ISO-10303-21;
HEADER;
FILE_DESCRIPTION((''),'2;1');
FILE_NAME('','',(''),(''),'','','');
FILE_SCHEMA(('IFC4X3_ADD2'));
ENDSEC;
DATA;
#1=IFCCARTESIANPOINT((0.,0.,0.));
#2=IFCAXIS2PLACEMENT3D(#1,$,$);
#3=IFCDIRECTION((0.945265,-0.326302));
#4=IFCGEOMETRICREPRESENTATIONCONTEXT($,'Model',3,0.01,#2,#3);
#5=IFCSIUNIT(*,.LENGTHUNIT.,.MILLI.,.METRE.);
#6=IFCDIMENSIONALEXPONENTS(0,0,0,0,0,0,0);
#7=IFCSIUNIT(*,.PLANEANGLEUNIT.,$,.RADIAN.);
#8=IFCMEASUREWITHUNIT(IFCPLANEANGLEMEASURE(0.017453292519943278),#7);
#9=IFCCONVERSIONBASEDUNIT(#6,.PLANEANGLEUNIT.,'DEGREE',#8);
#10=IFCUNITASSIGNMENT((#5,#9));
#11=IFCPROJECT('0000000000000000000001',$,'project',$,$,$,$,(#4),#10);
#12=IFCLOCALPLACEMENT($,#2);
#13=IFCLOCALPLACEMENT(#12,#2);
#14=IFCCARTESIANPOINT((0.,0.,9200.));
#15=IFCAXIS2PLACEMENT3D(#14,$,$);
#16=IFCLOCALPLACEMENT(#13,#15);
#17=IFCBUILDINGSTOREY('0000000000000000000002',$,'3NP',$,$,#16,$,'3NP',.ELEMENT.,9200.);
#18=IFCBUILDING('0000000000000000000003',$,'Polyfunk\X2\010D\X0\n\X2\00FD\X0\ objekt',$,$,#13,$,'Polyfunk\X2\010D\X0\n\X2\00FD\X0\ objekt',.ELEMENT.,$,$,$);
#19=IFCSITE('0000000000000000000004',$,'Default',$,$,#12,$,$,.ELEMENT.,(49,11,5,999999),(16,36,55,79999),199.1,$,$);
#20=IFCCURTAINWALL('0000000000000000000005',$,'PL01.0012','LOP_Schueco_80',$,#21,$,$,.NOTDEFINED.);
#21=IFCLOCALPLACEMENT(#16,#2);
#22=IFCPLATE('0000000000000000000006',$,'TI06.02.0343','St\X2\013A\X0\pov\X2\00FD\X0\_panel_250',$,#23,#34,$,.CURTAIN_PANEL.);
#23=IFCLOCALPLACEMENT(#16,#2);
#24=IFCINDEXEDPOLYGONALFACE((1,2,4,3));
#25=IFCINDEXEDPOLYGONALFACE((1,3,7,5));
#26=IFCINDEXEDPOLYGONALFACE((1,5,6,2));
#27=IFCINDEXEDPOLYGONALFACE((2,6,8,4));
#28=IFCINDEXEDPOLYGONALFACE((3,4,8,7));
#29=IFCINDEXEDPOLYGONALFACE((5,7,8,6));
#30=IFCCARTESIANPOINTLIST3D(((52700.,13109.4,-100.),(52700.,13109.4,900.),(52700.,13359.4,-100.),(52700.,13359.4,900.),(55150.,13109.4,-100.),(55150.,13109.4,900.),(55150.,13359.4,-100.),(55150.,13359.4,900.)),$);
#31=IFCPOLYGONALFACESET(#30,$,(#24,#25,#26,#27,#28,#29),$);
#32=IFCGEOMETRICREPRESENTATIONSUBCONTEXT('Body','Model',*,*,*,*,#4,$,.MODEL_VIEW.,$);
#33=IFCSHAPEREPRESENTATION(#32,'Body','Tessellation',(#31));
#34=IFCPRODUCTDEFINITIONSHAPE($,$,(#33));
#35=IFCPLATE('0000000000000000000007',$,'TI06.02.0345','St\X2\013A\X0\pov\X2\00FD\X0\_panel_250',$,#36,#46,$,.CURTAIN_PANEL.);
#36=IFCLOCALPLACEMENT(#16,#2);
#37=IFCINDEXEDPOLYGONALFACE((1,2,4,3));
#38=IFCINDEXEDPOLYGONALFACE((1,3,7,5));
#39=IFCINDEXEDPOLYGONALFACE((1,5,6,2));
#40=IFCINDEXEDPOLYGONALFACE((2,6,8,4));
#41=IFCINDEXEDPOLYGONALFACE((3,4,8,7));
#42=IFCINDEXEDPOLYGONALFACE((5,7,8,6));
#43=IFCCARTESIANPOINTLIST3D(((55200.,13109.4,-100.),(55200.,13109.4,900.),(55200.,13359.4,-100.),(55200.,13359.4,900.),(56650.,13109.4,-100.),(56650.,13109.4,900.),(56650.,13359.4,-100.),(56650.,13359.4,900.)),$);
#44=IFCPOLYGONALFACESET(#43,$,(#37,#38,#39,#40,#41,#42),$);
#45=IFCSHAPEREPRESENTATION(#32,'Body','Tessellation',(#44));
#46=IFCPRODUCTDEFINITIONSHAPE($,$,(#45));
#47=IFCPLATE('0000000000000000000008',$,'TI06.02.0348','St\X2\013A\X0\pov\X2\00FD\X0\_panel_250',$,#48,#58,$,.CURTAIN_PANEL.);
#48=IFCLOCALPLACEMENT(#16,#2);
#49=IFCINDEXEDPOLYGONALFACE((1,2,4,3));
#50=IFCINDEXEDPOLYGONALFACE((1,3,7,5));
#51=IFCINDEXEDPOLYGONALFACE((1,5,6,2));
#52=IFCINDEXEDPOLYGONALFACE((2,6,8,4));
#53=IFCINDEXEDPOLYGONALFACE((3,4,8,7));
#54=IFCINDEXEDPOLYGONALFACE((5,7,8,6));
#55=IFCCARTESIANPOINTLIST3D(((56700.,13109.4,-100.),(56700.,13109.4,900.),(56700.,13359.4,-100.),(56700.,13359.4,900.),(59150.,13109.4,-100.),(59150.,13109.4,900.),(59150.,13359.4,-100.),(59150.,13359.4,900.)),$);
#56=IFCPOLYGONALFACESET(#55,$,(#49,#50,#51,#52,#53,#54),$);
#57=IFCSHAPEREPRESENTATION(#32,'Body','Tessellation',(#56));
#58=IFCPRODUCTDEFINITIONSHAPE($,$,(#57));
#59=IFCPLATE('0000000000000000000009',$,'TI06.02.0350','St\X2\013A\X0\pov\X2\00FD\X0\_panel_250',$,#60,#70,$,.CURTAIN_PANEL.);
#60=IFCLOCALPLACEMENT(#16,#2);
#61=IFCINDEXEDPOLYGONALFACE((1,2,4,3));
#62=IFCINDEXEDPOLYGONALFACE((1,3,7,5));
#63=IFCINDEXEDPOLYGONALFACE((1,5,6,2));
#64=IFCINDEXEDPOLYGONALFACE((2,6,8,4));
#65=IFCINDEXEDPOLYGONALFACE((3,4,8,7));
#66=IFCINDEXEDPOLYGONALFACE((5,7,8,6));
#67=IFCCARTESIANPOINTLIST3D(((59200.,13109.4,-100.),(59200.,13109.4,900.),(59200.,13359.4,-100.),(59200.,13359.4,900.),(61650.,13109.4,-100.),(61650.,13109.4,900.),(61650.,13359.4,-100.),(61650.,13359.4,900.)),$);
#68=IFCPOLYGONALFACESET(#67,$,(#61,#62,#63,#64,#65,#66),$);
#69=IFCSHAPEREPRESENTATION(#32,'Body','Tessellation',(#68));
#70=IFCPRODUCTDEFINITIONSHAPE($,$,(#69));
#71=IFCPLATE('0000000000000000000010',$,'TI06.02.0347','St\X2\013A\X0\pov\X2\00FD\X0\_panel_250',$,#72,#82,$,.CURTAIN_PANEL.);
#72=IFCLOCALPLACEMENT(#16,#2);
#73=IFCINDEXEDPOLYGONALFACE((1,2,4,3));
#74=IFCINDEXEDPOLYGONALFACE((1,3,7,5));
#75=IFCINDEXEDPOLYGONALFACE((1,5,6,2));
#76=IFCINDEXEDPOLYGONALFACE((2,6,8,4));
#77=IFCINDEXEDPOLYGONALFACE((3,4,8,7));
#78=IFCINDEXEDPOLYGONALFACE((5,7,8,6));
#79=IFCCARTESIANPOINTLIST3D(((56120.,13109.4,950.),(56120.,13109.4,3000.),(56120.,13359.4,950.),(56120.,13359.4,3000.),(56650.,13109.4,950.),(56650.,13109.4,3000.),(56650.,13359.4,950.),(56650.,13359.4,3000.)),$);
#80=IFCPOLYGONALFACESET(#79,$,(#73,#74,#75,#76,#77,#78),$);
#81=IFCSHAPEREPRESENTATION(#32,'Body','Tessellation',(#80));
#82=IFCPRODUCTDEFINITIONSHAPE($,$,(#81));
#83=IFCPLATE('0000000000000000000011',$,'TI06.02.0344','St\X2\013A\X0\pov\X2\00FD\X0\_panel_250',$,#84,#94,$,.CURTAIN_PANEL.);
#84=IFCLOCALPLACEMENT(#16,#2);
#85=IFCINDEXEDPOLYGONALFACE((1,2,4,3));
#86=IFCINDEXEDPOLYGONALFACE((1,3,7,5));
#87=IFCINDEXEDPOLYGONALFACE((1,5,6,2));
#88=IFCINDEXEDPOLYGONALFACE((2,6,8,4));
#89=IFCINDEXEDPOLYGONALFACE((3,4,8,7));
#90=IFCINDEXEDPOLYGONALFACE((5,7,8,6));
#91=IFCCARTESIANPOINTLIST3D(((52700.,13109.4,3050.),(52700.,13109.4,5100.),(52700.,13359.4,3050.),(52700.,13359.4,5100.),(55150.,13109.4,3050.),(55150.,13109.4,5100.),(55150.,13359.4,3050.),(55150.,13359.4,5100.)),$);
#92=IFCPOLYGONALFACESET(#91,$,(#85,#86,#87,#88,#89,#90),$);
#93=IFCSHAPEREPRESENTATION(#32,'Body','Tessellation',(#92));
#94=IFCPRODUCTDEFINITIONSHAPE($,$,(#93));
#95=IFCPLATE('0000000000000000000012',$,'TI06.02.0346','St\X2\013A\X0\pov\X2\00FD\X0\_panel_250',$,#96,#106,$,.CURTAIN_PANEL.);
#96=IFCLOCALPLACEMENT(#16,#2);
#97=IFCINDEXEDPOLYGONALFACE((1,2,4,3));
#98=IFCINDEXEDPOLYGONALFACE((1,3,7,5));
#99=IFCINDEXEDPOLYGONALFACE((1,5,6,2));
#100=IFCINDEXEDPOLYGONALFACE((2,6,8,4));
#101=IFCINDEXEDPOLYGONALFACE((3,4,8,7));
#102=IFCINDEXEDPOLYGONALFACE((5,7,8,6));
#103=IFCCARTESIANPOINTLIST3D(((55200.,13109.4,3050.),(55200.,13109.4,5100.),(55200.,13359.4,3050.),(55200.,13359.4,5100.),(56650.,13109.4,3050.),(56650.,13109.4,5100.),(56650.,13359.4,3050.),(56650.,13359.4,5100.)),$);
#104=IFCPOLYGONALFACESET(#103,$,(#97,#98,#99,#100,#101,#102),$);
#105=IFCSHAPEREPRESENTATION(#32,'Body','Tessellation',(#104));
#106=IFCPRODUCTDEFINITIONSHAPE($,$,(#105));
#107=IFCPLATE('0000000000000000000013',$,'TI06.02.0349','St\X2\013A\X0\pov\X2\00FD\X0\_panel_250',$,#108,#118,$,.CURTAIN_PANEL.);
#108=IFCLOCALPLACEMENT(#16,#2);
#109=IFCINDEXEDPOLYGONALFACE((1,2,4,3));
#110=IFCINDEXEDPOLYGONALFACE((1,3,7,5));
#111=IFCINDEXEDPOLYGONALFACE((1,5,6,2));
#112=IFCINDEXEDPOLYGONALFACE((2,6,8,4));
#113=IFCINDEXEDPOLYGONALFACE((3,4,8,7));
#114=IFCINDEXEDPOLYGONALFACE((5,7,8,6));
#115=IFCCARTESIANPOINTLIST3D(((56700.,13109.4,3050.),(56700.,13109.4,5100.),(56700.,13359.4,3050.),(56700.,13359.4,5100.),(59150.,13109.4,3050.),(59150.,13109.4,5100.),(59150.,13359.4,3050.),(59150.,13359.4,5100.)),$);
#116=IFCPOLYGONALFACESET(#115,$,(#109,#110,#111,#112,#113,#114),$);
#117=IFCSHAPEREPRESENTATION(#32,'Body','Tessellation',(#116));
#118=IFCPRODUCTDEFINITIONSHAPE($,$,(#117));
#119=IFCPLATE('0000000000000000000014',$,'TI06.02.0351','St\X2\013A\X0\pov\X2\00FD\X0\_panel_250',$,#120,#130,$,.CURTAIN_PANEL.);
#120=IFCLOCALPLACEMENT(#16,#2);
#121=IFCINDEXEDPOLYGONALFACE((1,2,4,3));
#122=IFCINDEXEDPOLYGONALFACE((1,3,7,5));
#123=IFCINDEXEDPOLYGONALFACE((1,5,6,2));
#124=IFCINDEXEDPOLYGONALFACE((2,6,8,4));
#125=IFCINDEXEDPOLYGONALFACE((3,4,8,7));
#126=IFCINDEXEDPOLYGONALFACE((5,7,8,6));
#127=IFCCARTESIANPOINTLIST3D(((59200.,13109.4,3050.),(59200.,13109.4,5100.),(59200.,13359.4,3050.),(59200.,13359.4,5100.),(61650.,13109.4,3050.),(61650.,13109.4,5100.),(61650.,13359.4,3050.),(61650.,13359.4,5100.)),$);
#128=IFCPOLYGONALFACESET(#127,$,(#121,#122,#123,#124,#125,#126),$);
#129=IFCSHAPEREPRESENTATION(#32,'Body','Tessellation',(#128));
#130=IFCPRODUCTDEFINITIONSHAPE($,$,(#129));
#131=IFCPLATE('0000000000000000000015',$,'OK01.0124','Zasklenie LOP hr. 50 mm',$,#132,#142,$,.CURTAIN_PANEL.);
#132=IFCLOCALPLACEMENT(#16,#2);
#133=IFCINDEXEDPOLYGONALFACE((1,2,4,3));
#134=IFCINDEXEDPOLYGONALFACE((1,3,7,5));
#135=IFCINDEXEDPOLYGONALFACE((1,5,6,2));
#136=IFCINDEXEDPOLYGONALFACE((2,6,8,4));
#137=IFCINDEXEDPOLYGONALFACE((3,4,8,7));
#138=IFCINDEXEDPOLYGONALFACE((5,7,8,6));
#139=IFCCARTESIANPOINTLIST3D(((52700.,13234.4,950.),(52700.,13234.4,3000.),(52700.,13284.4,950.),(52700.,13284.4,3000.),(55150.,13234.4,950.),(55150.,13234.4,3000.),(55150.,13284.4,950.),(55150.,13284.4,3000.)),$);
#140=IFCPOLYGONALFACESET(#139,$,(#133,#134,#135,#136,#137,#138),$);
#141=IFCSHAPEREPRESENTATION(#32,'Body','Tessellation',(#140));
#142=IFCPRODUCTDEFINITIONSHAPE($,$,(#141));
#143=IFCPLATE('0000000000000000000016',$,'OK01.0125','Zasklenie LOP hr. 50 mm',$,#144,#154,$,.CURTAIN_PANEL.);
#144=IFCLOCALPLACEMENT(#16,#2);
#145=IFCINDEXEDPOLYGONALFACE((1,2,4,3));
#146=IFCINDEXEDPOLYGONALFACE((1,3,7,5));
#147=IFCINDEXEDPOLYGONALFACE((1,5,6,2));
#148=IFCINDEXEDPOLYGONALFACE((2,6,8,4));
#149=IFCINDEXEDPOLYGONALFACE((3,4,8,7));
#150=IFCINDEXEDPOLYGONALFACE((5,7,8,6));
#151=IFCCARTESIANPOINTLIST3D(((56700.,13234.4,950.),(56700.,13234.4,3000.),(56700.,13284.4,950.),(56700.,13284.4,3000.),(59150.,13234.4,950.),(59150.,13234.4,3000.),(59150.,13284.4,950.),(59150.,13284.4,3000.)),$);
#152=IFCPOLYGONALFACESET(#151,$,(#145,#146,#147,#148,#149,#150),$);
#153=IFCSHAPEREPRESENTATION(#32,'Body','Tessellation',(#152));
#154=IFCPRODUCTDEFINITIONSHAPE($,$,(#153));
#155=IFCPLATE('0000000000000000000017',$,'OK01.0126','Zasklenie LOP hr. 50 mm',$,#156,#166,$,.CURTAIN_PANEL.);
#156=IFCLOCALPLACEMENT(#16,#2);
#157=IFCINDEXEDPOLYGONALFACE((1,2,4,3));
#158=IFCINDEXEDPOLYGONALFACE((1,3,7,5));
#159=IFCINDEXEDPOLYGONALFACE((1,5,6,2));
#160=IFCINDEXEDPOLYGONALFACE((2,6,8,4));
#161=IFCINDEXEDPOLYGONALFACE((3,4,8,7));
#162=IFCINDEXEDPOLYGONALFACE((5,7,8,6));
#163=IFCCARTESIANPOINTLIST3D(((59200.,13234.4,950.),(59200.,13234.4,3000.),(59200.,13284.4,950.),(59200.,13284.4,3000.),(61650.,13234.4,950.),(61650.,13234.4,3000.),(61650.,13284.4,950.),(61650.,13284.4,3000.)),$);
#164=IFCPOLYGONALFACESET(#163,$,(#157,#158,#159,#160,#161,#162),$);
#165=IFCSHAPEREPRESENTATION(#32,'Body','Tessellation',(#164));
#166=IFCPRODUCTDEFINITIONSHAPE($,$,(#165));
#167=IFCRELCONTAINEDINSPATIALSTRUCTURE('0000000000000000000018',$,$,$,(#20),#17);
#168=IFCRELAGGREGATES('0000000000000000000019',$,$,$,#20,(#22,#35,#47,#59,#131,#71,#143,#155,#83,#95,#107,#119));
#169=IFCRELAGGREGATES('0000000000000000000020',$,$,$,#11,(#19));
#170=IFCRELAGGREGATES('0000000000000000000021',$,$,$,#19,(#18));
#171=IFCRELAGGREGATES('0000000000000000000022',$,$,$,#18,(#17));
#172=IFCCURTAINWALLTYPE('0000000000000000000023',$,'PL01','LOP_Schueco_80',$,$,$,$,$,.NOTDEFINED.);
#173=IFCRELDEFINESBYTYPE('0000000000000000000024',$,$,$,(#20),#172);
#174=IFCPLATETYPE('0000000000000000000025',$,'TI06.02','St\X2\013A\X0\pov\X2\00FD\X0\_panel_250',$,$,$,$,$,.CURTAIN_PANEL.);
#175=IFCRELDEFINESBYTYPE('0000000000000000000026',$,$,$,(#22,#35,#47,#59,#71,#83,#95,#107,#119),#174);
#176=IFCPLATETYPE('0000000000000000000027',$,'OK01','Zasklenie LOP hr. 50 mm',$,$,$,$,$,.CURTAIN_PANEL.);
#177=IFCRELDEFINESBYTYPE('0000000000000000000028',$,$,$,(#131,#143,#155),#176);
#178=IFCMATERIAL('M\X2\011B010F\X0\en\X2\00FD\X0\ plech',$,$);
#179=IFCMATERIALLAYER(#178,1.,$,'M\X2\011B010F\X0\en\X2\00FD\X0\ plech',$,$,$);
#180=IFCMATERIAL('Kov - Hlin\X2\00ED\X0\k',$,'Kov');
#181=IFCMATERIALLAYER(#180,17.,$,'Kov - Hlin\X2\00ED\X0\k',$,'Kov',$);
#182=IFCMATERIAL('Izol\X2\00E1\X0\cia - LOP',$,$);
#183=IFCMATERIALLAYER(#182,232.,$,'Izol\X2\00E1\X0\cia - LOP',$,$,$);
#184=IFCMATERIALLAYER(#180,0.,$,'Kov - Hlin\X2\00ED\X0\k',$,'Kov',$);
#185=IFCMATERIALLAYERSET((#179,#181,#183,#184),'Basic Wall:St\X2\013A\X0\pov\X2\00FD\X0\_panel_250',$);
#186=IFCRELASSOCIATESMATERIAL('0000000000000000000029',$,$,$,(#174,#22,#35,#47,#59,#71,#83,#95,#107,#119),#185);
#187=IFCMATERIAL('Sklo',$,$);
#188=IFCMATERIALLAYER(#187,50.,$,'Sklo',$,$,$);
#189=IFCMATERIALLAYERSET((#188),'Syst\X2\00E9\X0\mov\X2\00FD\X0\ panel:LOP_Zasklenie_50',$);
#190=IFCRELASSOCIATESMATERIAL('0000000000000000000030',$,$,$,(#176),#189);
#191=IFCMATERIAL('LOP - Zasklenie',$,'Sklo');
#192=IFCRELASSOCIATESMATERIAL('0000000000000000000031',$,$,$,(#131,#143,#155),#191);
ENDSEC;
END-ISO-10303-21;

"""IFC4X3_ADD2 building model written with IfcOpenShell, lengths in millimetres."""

from ifc_helpers import new_model, entity, si_unit, converted_unit, direction, frame, frame_2d, origin, origin_2d_with_axis, place, context, subcontext, project, spatial, rectangle, extrude, source, transform, mapped, material, layer, layer_set, layer_usage, type_object, type_shapes, element, aggregate, save


model = new_model("IFC4X3_ADD2")

# Units and contexts
model_context = context("Model", 3, precision=0.01, world=origin(), true_north=direction((0.945265, -0.326302)))
body_context = subcontext(model_context, "Body", "Model", "MODEL_VIEW")
ifc_project = project(units=[si_unit("LENGTHUNIT", "METRE", prefix="MILLI"), converted_unit("PLANEANGLEUNIT", "DEGREE", entity("IfcPlaneAngleMeasure", 0.017453292519943278), si_unit("PLANEANGLEUNIT", "RADIAN"), dimensions=[0, 0, 0, 0, 0, 0, 0])], contexts=[model_context])

# Site, building, storey
site_placement = place(None, origin())
site = spatial("IfcSite", under=ifc_project, at=site_placement, Name="Default", CompositionType="ELEMENT", RefLatitude=(49, 11, 5, 999999), RefLongitude=(16, 36, 55, 79999), RefElevation=199.1)
building_placement = place(site_placement, origin())
building = spatial("IfcBuilding", under=site, at=building_placement, Name="Polyfunkčný objekt", LongName="Polyfunkčný objekt", CompositionType="ELEMENT")
storey_placement = place(building_placement, frame((0.0, 0.0, 9200.0)))
storey = spatial("IfcBuildingStorey", under=building, at=storey_placement, Name="3NP", LongName="3NP", CompositionType="ELEMENT", Elevation=9200.0)

# Curtain wall, plates
curtain_wall_type = type_object("IfcCurtainWallType", Name="PL01", Description="LOP_Schueco_80", PredefinedType="NOTDEFINED")
curtain_wall_placement = place(storey_placement, frame((0.0, 0.0, -9200.0)))
curtain_wall = element("IfcCurtainWall", 1, at=curtain_wall_placement, inside=storey, type_object=curtain_wall_type, Name="PL01.0012", Description="LOP_Schueco_80", PredefinedType="NOTDEFINED")
ifc_material_1 = material(Name="Měďený plech")
ifc_layer_1 = layer(ifc_material_1, 1.0, Name="Měďený plech")
ifc_material_2 = material(Name="Kov - Hliník", Category="Kov")
ifc_layer_2 = layer(ifc_material_2, 17.0, Name="Kov - Hliník", Category="Kov")
ifc_material_3 = material(Name="Izolácia - LOP")
ifc_layer_3 = layer(ifc_material_3, 232.0, Name="Izolácia - LOP")
ifc_layer_4 = layer(ifc_material_2, 0.0, Name="Kov - Hliník", Category="Kov")
ifc_layer_set_1 = layer_set([ifc_layer_1, ifc_layer_2, ifc_layer_3, ifc_layer_4], Name="Basic Wall:Stĺpový_panel_250")
ifc_layer_usage_1 = layer_usage(ifc_layer_set_1, "AXIS2", "NEGATIVE", 125.0)
plate_type_1 = type_object("IfcPlateType", Name="TI06.02", Description="Stĺpový_panel_250", PredefinedType="CURTAIN_PANEL", material=ifc_layer_set_1)
plate_1_placement = place(storey_placement, frame((52700.0, 13234.4, -100.0)))
plate_1 = element("IfcPlate", 2, at=plate_1_placement, type_object=plate_type_1, material=ifc_layer_usage_1, Name="TI06.02.0343", Description="Stĺpový_panel_250", PredefinedType="CURTAIN_PANEL", context=body_context, shape_type="SweptSolid", body=[
    extrude(rectangle(XDim=250.0, YDim=2450.0, at=origin_2d_with_axis()), frame((1225.0, 0.0, 0.0), z_axis=(0.0, 0.0, 1.0), x_axis=(0.0, 1.0, 0.0)), (0.0, 0.0, 1.0), 1000.0),
])
ifc_layer_usage_2 = layer_usage(ifc_layer_set_1, "AXIS2", "NEGATIVE", 125.0)
plate_2_placement = place(storey_placement, frame((55200.0, 13234.4, -100.0)))
plate_2 = element("IfcPlate", 3, at=plate_2_placement, type_object=plate_type_1, material=ifc_layer_usage_2, Name="TI06.02.0345", Description="Stĺpový_panel_250", PredefinedType="CURTAIN_PANEL", context=body_context, shape_type="SweptSolid", body=[
    extrude(rectangle(XDim=250.0, YDim=1450.0, at=origin_2d_with_axis()), frame((725.0, 0.0, 0.0), z_axis=(0.0, 0.0, 1.0), x_axis=(0.0, 1.0, 0.0)), (0.0, 0.0, 1.0), 1000.0),
])
ifc_layer_usage_3 = layer_usage(ifc_layer_set_1, "AXIS2", "NEGATIVE", 125.0)
plate_3_placement = place(storey_placement, frame((56700.0, 13234.4, -100.0)))
plate_3 = element("IfcPlate", 4, at=plate_3_placement, type_object=plate_type_1, material=ifc_layer_usage_3, Name="TI06.02.0348", Description="Stĺpový_panel_250", PredefinedType="CURTAIN_PANEL", context=body_context, shape_type="SweptSolid", body=[
    extrude(rectangle(XDim=250.0, YDim=2450.0, at=frame_2d((0.0, 0.0), x_axis=(1.0, 0.0))), frame((1225.0, 0.0, 0.0), z_axis=(0.0, 0.0, 1.0), x_axis=(0.0, 1.0, 0.0)), (0.0, 0.0, 1.0), 1000.0),
])
ifc_layer_usage_4 = layer_usage(ifc_layer_set_1, "AXIS2", "NEGATIVE", 125.0)
plate_4_placement = place(storey_placement, frame((59200.0, 13234.4, -100.0)))
plate_4 = element("IfcPlate", 5, at=plate_4_placement, type_object=plate_type_1, material=ifc_layer_usage_4, Name="TI06.02.0350", Description="Stĺpový_panel_250", PredefinedType="CURTAIN_PANEL", context=body_context, shape_type="SweptSolid", body=[
    extrude(rectangle(XDim=250.0, YDim=2450.0, at=frame_2d((0.0, 0.0), x_axis=(1.0, 0.0))), frame((1225.0, 0.0, 0.0), z_axis=(0.0, 0.0, 1.0), x_axis=(0.0, 1.0, 0.0)), (0.0, 0.0, 1.0), 1000.0),
])
ifc_layer_usage_5 = layer_usage(ifc_layer_set_1, "AXIS2", "NEGATIVE", 125.0)
plate_5_placement = place(storey_placement, frame((56120.0, 13234.4, 950.0)))
plate_5 = element("IfcPlate", 6, at=plate_5_placement, type_object=plate_type_1, material=ifc_layer_usage_5, Name="TI06.02.0347", Description="Stĺpový_panel_250", PredefinedType="CURTAIN_PANEL", context=body_context, shape_type="SweptSolid", body=[
    extrude(rectangle(XDim=250.0, YDim=530.0, at=frame_2d((0.0, 0.0), x_axis=(1.0, 0.0))), frame((265.0, 0.0, 0.0), z_axis=(0.0, 0.0, 1.0), x_axis=(0.0, 1.0, 0.0)), (0.0, 0.0, 1.0), 2050.0),
])
ifc_layer_usage_6 = layer_usage(ifc_layer_set_1, "AXIS2", "NEGATIVE", 125.0)
plate_6_placement = place(storey_placement, frame((52700.0, 13234.4, 3050.0)))
plate_6 = element("IfcPlate", 7, at=plate_6_placement, type_object=plate_type_1, material=ifc_layer_usage_6, Name="TI06.02.0344", Description="Stĺpový_panel_250", PredefinedType="CURTAIN_PANEL", context=body_context, shape_type="SweptSolid", body=[
    extrude(rectangle(XDim=250.0, YDim=2450.0, at=origin_2d_with_axis()), frame((1225.0, 0.0, 0.0), z_axis=(0.0, 0.0, 1.0), x_axis=(0.0, 1.0, 0.0)), (0.0, 0.0, 1.0), 2050.0),
])
ifc_layer_usage_7 = layer_usage(ifc_layer_set_1, "AXIS2", "NEGATIVE", 125.0)
plate_7_placement = place(storey_placement, frame((55200.0, 13234.4, 3050.0)))
plate_7 = element("IfcPlate", 8, at=plate_7_placement, type_object=plate_type_1, material=ifc_layer_usage_7, Name="TI06.02.0346", Description="Stĺpový_panel_250", PredefinedType="CURTAIN_PANEL", context=body_context, shape_type="SweptSolid", body=[
    extrude(rectangle(XDim=250.0, YDim=1450.0, at=origin_2d_with_axis()), frame((725.0, 0.0, 0.0), z_axis=(0.0, 0.0, 1.0), x_axis=(0.0, 1.0, 0.0)), (0.0, 0.0, 1.0), 2050.0),
])
ifc_layer_usage_8 = layer_usage(ifc_layer_set_1, "AXIS2", "NEGATIVE", 125.0)
plate_8_placement = place(storey_placement, frame((56700.0, 13234.4, 3050.0)))
plate_8 = element("IfcPlate", 9, at=plate_8_placement, type_object=plate_type_1, material=ifc_layer_usage_8, Name="TI06.02.0349", Description="Stĺpový_panel_250", PredefinedType="CURTAIN_PANEL", context=body_context, shape_type="SweptSolid", body=[
    extrude(rectangle(XDim=250.0, YDim=2450.0, at=frame_2d((0.0, 0.0), x_axis=(1.0, 0.0))), frame((1225.0, 0.0, 0.0), z_axis=(0.0, 0.0, 1.0), x_axis=(0.0, 1.0, 0.0)), (0.0, 0.0, 1.0), 2050.0),
])
ifc_layer_usage_9 = layer_usage(ifc_layer_set_1, "AXIS2", "NEGATIVE", 125.0)
plate_9_placement = place(storey_placement, frame((59200.0, 13234.4, 3050.0)))
plate_9 = element("IfcPlate", 10, at=plate_9_placement, type_object=plate_type_1, material=ifc_layer_usage_9, Name="TI06.02.0351", Description="Stĺpový_panel_250", PredefinedType="CURTAIN_PANEL", context=body_context, shape_type="SweptSolid", body=[
    extrude(rectangle(XDim=250.0, YDim=2450.0, at=frame_2d((0.0, 0.0), x_axis=(1.0, 0.0))), frame((1225.0, 0.0, 0.0), z_axis=(0.0, 0.0, 1.0), x_axis=(0.0, 1.0, 0.0)), (0.0, 0.0, 1.0), 2050.0),
])
ifc_material_4 = material(Name="LOP - Zasklenie", Category="Sklo")
ifc_material_5 = material(Name="Sklo")
ifc_layer_5 = layer(ifc_material_5, 50.0, Name="Sklo")
ifc_layer_set_2 = layer_set([ifc_layer_5], Name="Systémový panel:LOP_Zasklenie_50")
plate_type_2 = type_object("IfcPlateType", Name="OK01", Description="Zasklenie LOP hr. 50 mm", PredefinedType="CURTAIN_PANEL", material=ifc_layer_set_2)
shared_shape_1 = source(origin(), body_context, "Body", "SweptSolid", [
    extrude(rectangle(XDim=50.0, YDim=2450.0, at=origin_2d_with_axis()), frame((0.0, 25.0, 0.0), z_axis=(0.0, 0.0, 1.0), x_axis=(0.0, 1.0, 0.0)), (0.0, 0.0, 1.0), 2050.0),
])
type_shapes(plate_type_2, [shared_shape_1])
plate_10_placement = place(curtain_wall_placement, frame((53925.0, 13234.4, 10150.0)))
plate_10 = element("IfcPlate", 11, at=plate_10_placement, type_object=plate_type_2, material=ifc_material_4, Name="OK01.0124", Description="Zasklenie LOP hr. 50 mm", PredefinedType="CURTAIN_PANEL", context=body_context, shape_type="MappedRepresentation", body=[
    mapped(shared_shape_1, transform((0.0, 0.0, 0.0), scale=1.0)),
])
plate_11_placement = place(curtain_wall_placement, frame((57925.0, 13234.4, 10150.0)))
plate_11 = element("IfcPlate", 12, at=plate_11_placement, type_object=plate_type_2, material=ifc_material_4, Name="OK01.0125", Description="Zasklenie LOP hr. 50 mm", PredefinedType="CURTAIN_PANEL", context=body_context, shape_type="MappedRepresentation", body=[
    mapped(shared_shape_1, transform((0.0, 0.0, 0.0), scale=1.0)),
])
plate_12_placement = place(curtain_wall_placement, frame((60425.0, 13234.4, 10150.0)))
plate_12 = element("IfcPlate", 13, at=plate_12_placement, type_object=plate_type_2, material=ifc_material_4, Name="OK01.0126", Description="Zasklenie LOP hr. 50 mm", PredefinedType="CURTAIN_PANEL", context=body_context, shape_type="MappedRepresentation", body=[
    mapped(shared_shape_1, transform((0.0, 0.0, 0.0), scale=1.0)),
])
aggregate(curtain_wall, [plate_1, plate_2, plate_3, plate_4, plate_10, plate_5, plate_11, plate_12, plate_6, plate_7, plate_8, plate_9])

save(model, "model.ifc")
